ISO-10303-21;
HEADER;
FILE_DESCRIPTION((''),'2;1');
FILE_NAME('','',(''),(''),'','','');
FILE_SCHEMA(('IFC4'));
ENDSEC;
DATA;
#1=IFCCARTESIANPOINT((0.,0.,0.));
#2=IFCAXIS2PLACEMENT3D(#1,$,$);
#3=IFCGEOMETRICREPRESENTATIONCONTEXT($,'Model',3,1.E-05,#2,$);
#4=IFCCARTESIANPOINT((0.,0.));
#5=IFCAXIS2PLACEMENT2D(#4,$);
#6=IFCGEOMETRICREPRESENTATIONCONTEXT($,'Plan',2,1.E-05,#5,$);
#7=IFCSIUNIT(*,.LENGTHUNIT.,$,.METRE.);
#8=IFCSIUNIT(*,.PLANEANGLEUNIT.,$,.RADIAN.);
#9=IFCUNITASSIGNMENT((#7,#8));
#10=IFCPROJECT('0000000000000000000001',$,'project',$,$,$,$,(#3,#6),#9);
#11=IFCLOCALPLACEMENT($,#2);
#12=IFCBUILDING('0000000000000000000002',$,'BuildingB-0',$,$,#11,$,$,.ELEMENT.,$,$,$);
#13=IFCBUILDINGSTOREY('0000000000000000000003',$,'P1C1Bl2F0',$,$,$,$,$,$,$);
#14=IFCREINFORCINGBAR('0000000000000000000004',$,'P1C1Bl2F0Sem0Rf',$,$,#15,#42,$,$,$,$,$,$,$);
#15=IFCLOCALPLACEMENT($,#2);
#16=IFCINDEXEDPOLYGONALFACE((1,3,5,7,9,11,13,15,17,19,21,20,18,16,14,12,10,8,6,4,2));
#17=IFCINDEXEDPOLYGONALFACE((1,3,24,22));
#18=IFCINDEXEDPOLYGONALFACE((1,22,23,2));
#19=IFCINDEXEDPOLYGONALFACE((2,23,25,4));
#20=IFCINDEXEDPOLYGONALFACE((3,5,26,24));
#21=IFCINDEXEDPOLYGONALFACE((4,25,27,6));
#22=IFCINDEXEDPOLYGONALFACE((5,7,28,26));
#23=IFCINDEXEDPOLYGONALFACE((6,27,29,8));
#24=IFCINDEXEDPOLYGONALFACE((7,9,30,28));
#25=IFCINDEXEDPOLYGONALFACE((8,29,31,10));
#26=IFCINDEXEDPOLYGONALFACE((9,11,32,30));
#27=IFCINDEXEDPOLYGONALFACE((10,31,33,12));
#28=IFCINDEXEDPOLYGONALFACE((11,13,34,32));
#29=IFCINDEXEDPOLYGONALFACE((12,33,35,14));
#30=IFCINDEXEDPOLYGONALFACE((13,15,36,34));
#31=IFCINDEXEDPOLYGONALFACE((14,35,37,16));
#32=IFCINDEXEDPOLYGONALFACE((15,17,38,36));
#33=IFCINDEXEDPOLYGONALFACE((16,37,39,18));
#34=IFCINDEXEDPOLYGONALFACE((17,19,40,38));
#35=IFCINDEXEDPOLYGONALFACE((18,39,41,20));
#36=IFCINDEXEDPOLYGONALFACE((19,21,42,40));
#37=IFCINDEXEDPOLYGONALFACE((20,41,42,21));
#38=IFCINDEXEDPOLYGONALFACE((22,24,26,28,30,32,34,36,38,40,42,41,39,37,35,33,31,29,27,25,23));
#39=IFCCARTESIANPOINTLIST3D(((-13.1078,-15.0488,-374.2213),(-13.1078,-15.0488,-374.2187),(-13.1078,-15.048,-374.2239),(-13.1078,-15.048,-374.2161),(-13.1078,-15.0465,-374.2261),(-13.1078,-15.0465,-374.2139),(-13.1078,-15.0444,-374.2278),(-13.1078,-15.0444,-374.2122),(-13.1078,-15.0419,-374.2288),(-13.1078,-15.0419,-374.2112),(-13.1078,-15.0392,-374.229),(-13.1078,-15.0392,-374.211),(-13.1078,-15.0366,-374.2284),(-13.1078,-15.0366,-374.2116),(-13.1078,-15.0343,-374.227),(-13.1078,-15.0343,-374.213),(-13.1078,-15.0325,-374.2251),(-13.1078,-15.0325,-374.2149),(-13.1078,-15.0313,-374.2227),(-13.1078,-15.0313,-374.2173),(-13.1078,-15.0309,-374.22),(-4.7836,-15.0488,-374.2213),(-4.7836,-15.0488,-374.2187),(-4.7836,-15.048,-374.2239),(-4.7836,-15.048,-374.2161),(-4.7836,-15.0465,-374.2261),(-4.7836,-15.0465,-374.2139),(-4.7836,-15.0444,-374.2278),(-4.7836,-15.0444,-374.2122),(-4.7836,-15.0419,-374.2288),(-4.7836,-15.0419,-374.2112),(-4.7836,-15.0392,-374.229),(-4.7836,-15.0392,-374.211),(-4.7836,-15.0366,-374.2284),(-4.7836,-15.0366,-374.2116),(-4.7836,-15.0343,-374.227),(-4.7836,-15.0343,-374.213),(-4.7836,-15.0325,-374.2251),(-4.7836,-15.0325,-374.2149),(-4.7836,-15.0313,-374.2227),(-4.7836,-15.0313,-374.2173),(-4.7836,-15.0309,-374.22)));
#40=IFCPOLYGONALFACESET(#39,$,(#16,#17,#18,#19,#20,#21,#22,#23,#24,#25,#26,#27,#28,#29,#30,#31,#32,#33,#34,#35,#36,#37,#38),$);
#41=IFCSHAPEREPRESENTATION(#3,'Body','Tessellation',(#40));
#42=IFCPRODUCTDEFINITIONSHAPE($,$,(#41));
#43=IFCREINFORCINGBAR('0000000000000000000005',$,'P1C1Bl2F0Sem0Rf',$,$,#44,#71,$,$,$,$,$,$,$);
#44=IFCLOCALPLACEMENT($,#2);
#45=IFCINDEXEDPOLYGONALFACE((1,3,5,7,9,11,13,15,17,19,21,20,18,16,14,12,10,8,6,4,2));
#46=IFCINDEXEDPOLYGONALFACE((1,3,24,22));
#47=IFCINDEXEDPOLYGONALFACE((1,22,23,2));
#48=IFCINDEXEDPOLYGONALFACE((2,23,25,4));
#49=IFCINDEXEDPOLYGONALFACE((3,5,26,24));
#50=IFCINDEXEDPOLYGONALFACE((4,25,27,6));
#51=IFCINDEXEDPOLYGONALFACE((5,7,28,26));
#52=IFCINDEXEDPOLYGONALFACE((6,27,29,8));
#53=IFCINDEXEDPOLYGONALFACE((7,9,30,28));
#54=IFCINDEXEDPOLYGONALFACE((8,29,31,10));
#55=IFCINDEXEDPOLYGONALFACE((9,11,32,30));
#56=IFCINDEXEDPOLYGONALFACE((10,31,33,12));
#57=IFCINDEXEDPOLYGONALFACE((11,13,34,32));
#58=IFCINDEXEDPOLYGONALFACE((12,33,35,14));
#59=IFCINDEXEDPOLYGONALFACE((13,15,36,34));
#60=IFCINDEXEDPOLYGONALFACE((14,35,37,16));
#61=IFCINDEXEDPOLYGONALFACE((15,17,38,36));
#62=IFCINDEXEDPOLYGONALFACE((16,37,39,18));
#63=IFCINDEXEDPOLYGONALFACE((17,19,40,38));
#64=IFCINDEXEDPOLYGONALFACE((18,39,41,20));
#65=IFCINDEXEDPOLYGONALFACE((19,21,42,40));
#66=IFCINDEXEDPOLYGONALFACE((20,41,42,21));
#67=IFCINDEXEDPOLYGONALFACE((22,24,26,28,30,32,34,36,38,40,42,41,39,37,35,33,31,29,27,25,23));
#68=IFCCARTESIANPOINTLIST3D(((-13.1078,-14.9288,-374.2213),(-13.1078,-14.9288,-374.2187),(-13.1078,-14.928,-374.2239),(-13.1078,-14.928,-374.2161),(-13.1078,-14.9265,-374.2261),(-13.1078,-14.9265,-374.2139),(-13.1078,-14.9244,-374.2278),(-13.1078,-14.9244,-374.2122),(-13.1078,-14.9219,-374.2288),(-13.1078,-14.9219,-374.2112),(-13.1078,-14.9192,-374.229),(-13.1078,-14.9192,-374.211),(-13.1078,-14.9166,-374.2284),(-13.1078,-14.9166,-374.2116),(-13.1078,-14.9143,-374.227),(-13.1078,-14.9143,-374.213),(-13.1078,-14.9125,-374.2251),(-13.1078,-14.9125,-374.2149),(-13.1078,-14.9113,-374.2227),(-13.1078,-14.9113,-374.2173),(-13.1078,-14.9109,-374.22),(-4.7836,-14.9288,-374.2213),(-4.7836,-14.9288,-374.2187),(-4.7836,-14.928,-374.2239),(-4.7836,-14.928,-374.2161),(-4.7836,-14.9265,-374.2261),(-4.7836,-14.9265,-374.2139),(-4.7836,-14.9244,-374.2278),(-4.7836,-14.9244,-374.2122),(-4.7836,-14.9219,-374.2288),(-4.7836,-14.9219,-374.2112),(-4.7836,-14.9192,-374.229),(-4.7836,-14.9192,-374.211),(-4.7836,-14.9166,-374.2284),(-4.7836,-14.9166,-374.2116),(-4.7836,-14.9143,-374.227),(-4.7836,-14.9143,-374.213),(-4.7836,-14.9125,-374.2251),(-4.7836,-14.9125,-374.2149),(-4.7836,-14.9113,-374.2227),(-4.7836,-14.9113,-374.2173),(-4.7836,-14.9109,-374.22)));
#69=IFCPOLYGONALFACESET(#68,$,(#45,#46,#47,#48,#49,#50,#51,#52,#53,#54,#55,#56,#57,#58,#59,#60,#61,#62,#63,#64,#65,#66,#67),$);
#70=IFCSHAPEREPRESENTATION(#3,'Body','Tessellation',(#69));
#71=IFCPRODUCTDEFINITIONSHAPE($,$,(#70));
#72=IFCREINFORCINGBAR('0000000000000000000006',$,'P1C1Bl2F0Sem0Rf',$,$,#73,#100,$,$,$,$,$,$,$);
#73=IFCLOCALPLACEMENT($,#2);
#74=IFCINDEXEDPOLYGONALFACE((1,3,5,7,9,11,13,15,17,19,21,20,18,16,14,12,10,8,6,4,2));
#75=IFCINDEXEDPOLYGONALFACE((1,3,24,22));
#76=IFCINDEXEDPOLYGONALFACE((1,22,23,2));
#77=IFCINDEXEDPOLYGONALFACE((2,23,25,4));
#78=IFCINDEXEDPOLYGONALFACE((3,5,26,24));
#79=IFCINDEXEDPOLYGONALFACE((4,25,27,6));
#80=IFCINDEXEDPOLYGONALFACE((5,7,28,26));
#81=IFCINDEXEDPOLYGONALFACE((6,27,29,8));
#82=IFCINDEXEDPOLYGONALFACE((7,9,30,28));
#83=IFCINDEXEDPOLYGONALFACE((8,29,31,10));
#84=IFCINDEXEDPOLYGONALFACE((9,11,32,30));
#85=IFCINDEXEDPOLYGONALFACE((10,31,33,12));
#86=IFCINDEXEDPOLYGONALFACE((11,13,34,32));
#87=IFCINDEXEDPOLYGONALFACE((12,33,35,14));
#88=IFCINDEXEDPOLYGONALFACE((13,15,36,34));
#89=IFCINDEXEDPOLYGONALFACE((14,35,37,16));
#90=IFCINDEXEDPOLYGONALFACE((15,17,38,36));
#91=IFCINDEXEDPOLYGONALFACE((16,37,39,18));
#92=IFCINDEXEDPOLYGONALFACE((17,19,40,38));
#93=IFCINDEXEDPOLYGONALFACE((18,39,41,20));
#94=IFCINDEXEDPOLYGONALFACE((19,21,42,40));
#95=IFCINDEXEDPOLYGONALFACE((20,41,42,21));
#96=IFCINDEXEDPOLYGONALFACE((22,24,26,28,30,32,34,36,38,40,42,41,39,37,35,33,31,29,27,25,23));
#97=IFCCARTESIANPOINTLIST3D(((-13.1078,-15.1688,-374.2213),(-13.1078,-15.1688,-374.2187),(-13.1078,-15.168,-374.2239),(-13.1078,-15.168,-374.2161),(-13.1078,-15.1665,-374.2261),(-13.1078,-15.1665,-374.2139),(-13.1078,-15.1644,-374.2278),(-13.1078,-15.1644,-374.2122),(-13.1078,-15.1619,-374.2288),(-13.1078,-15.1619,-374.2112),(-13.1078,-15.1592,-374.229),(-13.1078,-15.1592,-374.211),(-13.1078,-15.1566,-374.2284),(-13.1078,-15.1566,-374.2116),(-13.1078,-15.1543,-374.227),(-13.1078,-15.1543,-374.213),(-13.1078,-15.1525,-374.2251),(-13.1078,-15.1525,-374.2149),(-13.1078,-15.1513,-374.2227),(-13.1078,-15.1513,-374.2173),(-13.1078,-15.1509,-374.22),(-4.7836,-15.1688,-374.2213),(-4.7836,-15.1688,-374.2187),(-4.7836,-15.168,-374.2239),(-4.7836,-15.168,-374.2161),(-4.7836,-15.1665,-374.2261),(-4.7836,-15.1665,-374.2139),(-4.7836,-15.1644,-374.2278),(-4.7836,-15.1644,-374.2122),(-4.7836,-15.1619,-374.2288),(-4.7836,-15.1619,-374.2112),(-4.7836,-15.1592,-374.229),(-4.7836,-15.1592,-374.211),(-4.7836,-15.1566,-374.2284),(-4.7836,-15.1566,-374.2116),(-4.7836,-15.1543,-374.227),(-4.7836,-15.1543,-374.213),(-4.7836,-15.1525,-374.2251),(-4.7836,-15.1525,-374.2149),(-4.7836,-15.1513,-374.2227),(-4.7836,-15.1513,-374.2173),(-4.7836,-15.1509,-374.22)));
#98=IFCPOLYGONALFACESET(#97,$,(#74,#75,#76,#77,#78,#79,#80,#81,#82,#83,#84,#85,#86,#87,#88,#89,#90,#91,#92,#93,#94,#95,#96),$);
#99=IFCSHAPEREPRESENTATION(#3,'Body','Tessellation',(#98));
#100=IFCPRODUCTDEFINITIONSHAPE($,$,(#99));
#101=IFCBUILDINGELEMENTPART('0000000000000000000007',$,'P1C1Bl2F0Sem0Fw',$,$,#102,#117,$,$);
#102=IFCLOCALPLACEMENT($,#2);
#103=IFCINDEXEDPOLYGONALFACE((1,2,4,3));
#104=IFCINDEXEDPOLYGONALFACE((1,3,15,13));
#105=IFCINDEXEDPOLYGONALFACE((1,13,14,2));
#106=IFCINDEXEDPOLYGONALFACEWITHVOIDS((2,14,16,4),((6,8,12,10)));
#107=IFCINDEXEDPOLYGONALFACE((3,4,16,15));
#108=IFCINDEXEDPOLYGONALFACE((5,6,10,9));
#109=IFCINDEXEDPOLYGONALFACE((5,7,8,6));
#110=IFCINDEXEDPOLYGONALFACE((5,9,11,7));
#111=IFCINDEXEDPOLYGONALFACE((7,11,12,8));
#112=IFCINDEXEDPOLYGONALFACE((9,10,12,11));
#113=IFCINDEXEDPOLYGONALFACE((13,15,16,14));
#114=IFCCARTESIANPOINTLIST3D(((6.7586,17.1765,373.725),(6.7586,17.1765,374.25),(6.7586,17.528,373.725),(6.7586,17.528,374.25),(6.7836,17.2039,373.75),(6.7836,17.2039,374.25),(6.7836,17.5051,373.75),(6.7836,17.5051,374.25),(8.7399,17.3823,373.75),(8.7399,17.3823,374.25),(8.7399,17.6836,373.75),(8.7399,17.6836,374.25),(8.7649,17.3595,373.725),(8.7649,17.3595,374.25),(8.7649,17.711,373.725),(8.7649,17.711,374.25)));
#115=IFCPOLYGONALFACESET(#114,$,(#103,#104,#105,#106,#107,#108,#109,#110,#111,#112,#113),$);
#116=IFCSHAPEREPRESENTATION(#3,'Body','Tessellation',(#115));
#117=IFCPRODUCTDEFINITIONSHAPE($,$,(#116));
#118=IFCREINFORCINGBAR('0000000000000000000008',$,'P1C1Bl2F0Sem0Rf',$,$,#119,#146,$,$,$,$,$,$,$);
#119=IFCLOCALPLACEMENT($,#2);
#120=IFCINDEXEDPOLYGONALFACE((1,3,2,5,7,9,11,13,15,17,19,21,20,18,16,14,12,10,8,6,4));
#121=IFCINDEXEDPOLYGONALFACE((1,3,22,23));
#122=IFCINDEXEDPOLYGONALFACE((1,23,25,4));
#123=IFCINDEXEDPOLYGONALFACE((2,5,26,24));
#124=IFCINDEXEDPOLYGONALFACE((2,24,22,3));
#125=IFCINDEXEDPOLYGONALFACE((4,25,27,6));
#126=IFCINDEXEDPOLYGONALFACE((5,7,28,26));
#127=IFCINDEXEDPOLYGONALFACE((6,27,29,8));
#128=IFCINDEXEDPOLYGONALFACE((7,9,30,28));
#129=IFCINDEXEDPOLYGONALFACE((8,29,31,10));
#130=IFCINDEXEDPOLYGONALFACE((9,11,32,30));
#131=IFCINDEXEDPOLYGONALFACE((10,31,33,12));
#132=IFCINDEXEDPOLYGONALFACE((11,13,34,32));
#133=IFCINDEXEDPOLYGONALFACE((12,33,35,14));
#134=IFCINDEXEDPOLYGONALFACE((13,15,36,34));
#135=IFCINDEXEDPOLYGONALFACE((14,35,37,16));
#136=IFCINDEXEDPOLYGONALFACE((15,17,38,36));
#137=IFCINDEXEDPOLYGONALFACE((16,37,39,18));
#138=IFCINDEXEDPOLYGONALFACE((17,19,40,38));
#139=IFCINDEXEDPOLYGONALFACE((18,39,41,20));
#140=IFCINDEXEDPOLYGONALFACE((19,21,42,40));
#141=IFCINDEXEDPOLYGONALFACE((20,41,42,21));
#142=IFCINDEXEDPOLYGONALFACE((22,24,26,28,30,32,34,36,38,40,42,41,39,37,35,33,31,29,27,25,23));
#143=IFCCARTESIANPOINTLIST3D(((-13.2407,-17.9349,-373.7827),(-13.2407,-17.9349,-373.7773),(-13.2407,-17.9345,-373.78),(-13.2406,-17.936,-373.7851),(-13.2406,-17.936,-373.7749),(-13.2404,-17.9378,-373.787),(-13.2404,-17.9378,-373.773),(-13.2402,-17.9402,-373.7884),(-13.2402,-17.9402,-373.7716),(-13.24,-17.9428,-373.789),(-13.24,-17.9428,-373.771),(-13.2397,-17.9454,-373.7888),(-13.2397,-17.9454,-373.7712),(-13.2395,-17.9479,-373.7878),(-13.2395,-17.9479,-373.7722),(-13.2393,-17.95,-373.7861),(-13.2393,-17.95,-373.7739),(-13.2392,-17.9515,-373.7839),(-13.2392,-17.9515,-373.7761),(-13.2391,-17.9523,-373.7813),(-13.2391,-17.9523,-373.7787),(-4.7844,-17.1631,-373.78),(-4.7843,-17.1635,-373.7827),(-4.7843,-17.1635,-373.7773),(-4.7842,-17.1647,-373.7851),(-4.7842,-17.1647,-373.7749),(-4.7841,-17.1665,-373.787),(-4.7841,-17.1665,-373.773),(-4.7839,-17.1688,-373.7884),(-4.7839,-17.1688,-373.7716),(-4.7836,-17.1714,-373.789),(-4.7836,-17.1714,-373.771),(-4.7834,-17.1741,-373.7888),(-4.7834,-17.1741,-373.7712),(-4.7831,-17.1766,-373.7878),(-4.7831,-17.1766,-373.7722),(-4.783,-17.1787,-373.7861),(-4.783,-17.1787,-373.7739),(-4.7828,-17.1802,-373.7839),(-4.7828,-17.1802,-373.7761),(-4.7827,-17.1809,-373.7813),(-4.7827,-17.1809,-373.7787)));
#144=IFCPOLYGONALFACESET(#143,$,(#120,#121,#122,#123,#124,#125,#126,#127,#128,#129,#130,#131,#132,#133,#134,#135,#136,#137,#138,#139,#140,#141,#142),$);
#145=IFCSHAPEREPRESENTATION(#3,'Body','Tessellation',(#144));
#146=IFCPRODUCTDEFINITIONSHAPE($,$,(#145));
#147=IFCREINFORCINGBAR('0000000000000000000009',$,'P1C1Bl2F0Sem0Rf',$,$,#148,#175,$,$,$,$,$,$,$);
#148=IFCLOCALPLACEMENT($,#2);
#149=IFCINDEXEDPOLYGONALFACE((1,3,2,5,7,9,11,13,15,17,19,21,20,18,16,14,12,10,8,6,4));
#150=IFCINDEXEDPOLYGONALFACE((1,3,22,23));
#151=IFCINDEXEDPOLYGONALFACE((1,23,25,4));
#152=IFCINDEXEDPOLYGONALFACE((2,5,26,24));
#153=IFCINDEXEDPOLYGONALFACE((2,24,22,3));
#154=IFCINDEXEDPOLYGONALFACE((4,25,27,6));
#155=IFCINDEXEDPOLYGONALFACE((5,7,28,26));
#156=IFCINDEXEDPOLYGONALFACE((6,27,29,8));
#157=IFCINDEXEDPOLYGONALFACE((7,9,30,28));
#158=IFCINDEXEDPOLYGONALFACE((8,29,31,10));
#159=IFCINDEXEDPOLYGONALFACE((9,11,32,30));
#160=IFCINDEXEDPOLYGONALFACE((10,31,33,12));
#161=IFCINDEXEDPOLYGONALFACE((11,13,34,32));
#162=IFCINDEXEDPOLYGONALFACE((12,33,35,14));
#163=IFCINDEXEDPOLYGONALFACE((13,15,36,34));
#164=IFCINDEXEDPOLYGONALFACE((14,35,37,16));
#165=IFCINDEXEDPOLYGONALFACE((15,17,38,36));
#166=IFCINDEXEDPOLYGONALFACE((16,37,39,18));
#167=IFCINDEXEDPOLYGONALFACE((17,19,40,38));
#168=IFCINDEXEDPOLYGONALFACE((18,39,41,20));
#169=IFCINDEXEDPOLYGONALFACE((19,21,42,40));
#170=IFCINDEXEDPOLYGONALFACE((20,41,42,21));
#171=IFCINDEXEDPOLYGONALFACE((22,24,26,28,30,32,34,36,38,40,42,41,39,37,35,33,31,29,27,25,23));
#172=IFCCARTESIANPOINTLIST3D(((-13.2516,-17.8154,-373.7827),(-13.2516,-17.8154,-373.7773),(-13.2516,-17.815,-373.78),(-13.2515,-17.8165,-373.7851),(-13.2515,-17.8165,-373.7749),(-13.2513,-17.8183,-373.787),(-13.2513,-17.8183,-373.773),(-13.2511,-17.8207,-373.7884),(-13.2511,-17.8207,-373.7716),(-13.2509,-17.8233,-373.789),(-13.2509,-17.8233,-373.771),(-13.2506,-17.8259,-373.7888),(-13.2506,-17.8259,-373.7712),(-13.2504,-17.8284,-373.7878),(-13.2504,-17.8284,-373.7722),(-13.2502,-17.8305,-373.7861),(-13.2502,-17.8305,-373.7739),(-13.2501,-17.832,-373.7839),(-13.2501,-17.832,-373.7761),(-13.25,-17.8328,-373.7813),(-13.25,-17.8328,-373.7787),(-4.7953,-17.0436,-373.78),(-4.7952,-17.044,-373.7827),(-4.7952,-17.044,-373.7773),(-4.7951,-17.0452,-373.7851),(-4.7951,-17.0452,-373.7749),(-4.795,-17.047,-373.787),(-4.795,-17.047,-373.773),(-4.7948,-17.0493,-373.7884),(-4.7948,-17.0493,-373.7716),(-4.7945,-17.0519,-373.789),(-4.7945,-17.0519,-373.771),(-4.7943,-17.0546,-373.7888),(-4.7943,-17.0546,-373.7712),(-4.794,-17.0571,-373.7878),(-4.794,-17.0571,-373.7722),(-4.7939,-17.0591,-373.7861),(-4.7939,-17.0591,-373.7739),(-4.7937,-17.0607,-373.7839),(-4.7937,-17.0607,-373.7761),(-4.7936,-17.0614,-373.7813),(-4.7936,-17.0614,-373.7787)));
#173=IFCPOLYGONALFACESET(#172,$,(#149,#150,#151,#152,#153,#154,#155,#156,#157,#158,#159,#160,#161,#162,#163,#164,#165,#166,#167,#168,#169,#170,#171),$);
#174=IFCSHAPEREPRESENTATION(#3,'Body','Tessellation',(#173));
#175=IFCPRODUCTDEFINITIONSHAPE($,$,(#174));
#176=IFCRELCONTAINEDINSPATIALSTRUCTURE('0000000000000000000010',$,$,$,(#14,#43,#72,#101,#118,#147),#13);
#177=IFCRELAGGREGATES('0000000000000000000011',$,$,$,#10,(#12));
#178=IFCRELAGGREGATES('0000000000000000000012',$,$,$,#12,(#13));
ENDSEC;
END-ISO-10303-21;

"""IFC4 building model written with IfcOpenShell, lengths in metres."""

from ifc_helpers import new_model, entity, si_unit, origin, origin_2d, place, context, project, spatial, polyline, outline, extrude, element, save


model = new_model("IFC4")

# Units and contexts
model_context = context("Model", 3, precision=1e-05, world=origin())
plan_context = context("Plan", 2, precision=1e-05, world=origin_2d())
ifc_project = project(units=[si_unit("LENGTHUNIT", "METRE"), si_unit("PLANEANGLEUNIT", "RADIAN")], contexts=[model_context, plan_context])

# Building, storey
building_placement = place(None, origin())
building = spatial("IfcBuilding", under=ifc_project, at=building_placement, Name="BuildingB-0", CompositionType="ELEMENT")
storey = spatial("IfcBuildingStorey", under=building, Name="P1C1Bl2F0")

# Reinforcing bars
element("IfcReinforcingBar", 1, inside=storey, Name="P1C1Bl2F0Sem0Rf", context=model_context, shape_type="SweptSolid", body=[
    entity("IfcSurfaceCurveSweptAreaSolid", entity("IfcCircleProfileDef", "AREA", None, None, 0.009), None, entity("IfcPolyline", [entity("IfcCartesianPoint", [4.7836, 15.0399, 374.22]), entity("IfcCartesianPoint", [13.1078, 15.0399, 374.22])]), None, None, entity("IfcPlane", entity("IfcAxis2Placement3D", entity("IfcCartesianPoint", [4.7836, 15.0399, 374.22]), entity("IfcDirection", [0.0, 0.0, 1.0]), entity("IfcDirection", [1.0, 0.0, 0.0])))),
])
element("IfcReinforcingBar", 2, inside=storey, Name="P1C1Bl2F0Sem0Rf", context=model_context, shape_type="SweptSolid", body=[
    entity("IfcSurfaceCurveSweptAreaSolid", entity("IfcCircleProfileDef", "AREA", None, None, 0.009), None, entity("IfcPolyline", [entity("IfcCartesianPoint", [4.7836, 14.9199, 374.22]), entity("IfcCartesianPoint", [13.1078, 14.9199, 374.22])]), None, None, entity("IfcPlane", entity("IfcAxis2Placement3D", entity("IfcCartesianPoint", [4.7836, 14.9199, 374.22]), entity("IfcDirection", [0.0, 0.0, 1.0]), entity("IfcDirection", [1.0, 0.0, 0.0])))),
])
element("IfcReinforcingBar", 3, inside=storey, Name="P1C1Bl2F0Sem0Rf", context=model_context, shape_type="SweptSolid", body=[
    entity("IfcSurfaceCurveSweptAreaSolid", entity("IfcCircleProfileDef", "AREA", None, None, 0.009), None, entity("IfcPolyline", [entity("IfcCartesianPoint", [4.7836, 15.1599, 374.22]), entity("IfcCartesianPoint", [13.1078, 15.1599, 374.22])]), None, None, entity("IfcPlane", entity("IfcAxis2Placement3D", entity("IfcCartesianPoint", [4.7836, 15.1599, 374.22]), entity("IfcDirection", [0.0, 0.0, 1.0]), entity("IfcDirection", [1.0, 0.0, 0.0])))),
])

# Building element part, opening
building_element_part_1 = element("IfcBuildingElementPart", 4, inside=storey, Name="P1C1Bl2F0Sem0Fw", context=model_context, shape_type="SweptSolid", body=[
    extrude(outline(polyline([(6.7586, 17.1765, 373.725), (6.7586, 17.528, 373.725), (8.7649, 17.711, 373.725), (8.7649, 17.3595, 373.725), (6.7586, 17.1765, 373.725)])), None, (0.0, 0.0, 1.0), 0.525),
])
element("IfcOpeningElement", 5, inside=storey, cuts=building_element_part_1, context=model_context, shape_type="SweptSolid", body=[
    extrude(outline(polyline([(6.7836, 17.2039, 373.75), (6.7836, 17.5051, 373.75), (8.7399, 17.6836, 373.75), (8.7399, 17.3823, 373.75), (6.7836, 17.2039, 373.75)])), None, (0.0, 0.0, 1.0), 0.5),
])

# Reinforcing bars
element("IfcReinforcingBar", 6, inside=storey, Name="P1C1Bl2F0Sem0Rf", context=model_context, shape_type="SweptSolid", body=[
    entity("IfcSurfaceCurveSweptAreaSolid", entity("IfcCircleProfileDef", "AREA", None, None, 0.009), None, entity("IfcPolyline", [entity("IfcCartesianPoint", [4.7836, 17.1721, 373.78]), entity("IfcCartesianPoint", [13.2399, 17.9434, 373.78])]), None, None, entity("IfcPlane", entity("IfcAxis2Placement3D", entity("IfcCartesianPoint", [4.7836, 17.1721, 373.78]), entity("IfcDirection", [0.0, 0.0, 1.0]), entity("IfcDirection", [1.0, 0.0, 0.0])))),
])
element("IfcReinforcingBar", 7, inside=storey, Name="P1C1Bl2F0Sem0Rf", context=model_context, shape_type="SweptSolid", body=[
    entity("IfcSurfaceCurveSweptAreaSolid", entity("IfcCircleProfileDef", "AREA", None, None, 0.009), None, entity("IfcPolyline", [entity("IfcCartesianPoint", [4.7945, 17.0526, 373.78]), entity("IfcCartesianPoint", [13.2508, 17.8239, 373.78])]), None, None, entity("IfcPlane", entity("IfcAxis2Placement3D", entity("IfcCartesianPoint", [4.7945, 17.0526, 373.78]), entity("IfcDirection", [0.0, 0.0, 1.0]), entity("IfcDirection", [1.0, 0.0, 0.0])))),
])

save(model, "model.ifc")
